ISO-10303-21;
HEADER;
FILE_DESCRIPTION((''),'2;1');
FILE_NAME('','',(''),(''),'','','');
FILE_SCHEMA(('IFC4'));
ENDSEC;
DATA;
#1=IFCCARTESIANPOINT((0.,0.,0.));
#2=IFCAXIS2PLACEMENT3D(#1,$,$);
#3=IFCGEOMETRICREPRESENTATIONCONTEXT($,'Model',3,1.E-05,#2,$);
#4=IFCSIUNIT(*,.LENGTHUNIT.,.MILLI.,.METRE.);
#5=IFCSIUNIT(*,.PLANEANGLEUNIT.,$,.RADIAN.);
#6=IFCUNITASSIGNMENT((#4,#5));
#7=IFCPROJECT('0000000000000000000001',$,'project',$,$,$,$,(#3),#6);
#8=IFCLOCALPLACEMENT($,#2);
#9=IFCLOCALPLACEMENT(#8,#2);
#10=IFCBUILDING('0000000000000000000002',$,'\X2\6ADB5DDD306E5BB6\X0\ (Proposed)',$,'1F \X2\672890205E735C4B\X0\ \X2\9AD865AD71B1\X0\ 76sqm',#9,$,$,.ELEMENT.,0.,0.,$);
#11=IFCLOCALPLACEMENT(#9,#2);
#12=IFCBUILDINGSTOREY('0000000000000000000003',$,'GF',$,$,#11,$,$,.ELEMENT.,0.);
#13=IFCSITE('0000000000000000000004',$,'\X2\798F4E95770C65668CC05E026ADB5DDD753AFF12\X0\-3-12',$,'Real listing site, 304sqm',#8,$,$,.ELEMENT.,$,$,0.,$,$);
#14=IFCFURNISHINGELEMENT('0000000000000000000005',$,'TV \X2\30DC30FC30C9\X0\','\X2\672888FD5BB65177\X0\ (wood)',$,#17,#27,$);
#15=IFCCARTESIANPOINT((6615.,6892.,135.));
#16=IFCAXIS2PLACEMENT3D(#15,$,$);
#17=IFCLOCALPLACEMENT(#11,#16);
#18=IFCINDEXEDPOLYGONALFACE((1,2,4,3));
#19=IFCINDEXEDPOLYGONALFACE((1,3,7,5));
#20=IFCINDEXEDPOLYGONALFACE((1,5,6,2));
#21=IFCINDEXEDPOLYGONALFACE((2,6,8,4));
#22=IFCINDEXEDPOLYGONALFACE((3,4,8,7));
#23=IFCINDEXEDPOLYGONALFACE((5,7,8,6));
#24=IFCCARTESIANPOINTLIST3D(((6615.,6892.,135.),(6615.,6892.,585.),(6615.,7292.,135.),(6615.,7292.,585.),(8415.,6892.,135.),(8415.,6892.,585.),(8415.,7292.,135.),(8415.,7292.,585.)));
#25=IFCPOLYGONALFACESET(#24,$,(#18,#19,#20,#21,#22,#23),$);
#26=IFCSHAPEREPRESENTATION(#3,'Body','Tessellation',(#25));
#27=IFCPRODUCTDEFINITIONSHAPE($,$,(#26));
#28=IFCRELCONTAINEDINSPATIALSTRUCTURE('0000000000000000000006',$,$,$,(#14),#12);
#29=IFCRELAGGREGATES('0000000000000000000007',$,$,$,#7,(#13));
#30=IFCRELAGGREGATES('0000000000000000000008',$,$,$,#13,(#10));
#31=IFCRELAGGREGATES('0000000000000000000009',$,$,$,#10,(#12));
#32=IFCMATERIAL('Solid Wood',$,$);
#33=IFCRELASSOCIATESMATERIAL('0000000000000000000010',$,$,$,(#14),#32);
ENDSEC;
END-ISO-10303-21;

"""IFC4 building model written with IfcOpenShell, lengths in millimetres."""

from ifc_helpers import new_model, si_unit, frame, frame_2d, origin, place, context, project, spatial, rectangle, extrude, material, element, save


model = new_model("IFC4")

# Units and contexts
model_context = context("Model", 3, precision=1e-05, world=origin())
ifc_project = project(units=[si_unit("LENGTHUNIT", "METRE", prefix="MILLI"), si_unit("PLANEANGLEUNIT", "RADIAN")], contexts=[model_context])

# Site, building, storey
site_placement = place(None, origin())
site = spatial("IfcSite", under=ifc_project, at=site_placement, Name="福井県敦賀市櫛川町２-3-12", ObjectType="Real listing site, 304sqm", CompositionType="ELEMENT", RefElevation=0.0)
building_placement = place(site_placement, origin())
building = spatial("IfcBuilding", under=site, at=building_placement, Name="櫛川の家 (Proposed)", ObjectType="1F 木造平屋 高断熱 76sqm", CompositionType="ELEMENT", ElevationOfRefHeight=0.0, ElevationOfTerrain=0.0)
storey_placement = place(building_placement, origin())
storey = spatial("IfcBuildingStorey", under=building, at=storey_placement, Name="GF", CompositionType="ELEMENT", Elevation=0.0)

# Shared definitions
ifc_material_1 = material(Name="Solid Wood")

# Furnishing element
furnishing_1_placement = place(storey_placement, frame((6615.0, 6892.0, 135.0)))
element("IfcFurnishingElement", 1, at=furnishing_1_placement, inside=storey, material=ifc_material_1, Name="TV ボード", Description="木製家具 (wood)", context=model_context, shape_type="SweptSolid", body=[
    extrude(rectangle(XDim=1800.0, YDim=400.0, at=frame_2d((900.0, 200.0))), frame((6615.0, 6892.0, 135.0)), (0.0, 0.0, 1.0), 450.0),
])

save(model, "model.ifc")
